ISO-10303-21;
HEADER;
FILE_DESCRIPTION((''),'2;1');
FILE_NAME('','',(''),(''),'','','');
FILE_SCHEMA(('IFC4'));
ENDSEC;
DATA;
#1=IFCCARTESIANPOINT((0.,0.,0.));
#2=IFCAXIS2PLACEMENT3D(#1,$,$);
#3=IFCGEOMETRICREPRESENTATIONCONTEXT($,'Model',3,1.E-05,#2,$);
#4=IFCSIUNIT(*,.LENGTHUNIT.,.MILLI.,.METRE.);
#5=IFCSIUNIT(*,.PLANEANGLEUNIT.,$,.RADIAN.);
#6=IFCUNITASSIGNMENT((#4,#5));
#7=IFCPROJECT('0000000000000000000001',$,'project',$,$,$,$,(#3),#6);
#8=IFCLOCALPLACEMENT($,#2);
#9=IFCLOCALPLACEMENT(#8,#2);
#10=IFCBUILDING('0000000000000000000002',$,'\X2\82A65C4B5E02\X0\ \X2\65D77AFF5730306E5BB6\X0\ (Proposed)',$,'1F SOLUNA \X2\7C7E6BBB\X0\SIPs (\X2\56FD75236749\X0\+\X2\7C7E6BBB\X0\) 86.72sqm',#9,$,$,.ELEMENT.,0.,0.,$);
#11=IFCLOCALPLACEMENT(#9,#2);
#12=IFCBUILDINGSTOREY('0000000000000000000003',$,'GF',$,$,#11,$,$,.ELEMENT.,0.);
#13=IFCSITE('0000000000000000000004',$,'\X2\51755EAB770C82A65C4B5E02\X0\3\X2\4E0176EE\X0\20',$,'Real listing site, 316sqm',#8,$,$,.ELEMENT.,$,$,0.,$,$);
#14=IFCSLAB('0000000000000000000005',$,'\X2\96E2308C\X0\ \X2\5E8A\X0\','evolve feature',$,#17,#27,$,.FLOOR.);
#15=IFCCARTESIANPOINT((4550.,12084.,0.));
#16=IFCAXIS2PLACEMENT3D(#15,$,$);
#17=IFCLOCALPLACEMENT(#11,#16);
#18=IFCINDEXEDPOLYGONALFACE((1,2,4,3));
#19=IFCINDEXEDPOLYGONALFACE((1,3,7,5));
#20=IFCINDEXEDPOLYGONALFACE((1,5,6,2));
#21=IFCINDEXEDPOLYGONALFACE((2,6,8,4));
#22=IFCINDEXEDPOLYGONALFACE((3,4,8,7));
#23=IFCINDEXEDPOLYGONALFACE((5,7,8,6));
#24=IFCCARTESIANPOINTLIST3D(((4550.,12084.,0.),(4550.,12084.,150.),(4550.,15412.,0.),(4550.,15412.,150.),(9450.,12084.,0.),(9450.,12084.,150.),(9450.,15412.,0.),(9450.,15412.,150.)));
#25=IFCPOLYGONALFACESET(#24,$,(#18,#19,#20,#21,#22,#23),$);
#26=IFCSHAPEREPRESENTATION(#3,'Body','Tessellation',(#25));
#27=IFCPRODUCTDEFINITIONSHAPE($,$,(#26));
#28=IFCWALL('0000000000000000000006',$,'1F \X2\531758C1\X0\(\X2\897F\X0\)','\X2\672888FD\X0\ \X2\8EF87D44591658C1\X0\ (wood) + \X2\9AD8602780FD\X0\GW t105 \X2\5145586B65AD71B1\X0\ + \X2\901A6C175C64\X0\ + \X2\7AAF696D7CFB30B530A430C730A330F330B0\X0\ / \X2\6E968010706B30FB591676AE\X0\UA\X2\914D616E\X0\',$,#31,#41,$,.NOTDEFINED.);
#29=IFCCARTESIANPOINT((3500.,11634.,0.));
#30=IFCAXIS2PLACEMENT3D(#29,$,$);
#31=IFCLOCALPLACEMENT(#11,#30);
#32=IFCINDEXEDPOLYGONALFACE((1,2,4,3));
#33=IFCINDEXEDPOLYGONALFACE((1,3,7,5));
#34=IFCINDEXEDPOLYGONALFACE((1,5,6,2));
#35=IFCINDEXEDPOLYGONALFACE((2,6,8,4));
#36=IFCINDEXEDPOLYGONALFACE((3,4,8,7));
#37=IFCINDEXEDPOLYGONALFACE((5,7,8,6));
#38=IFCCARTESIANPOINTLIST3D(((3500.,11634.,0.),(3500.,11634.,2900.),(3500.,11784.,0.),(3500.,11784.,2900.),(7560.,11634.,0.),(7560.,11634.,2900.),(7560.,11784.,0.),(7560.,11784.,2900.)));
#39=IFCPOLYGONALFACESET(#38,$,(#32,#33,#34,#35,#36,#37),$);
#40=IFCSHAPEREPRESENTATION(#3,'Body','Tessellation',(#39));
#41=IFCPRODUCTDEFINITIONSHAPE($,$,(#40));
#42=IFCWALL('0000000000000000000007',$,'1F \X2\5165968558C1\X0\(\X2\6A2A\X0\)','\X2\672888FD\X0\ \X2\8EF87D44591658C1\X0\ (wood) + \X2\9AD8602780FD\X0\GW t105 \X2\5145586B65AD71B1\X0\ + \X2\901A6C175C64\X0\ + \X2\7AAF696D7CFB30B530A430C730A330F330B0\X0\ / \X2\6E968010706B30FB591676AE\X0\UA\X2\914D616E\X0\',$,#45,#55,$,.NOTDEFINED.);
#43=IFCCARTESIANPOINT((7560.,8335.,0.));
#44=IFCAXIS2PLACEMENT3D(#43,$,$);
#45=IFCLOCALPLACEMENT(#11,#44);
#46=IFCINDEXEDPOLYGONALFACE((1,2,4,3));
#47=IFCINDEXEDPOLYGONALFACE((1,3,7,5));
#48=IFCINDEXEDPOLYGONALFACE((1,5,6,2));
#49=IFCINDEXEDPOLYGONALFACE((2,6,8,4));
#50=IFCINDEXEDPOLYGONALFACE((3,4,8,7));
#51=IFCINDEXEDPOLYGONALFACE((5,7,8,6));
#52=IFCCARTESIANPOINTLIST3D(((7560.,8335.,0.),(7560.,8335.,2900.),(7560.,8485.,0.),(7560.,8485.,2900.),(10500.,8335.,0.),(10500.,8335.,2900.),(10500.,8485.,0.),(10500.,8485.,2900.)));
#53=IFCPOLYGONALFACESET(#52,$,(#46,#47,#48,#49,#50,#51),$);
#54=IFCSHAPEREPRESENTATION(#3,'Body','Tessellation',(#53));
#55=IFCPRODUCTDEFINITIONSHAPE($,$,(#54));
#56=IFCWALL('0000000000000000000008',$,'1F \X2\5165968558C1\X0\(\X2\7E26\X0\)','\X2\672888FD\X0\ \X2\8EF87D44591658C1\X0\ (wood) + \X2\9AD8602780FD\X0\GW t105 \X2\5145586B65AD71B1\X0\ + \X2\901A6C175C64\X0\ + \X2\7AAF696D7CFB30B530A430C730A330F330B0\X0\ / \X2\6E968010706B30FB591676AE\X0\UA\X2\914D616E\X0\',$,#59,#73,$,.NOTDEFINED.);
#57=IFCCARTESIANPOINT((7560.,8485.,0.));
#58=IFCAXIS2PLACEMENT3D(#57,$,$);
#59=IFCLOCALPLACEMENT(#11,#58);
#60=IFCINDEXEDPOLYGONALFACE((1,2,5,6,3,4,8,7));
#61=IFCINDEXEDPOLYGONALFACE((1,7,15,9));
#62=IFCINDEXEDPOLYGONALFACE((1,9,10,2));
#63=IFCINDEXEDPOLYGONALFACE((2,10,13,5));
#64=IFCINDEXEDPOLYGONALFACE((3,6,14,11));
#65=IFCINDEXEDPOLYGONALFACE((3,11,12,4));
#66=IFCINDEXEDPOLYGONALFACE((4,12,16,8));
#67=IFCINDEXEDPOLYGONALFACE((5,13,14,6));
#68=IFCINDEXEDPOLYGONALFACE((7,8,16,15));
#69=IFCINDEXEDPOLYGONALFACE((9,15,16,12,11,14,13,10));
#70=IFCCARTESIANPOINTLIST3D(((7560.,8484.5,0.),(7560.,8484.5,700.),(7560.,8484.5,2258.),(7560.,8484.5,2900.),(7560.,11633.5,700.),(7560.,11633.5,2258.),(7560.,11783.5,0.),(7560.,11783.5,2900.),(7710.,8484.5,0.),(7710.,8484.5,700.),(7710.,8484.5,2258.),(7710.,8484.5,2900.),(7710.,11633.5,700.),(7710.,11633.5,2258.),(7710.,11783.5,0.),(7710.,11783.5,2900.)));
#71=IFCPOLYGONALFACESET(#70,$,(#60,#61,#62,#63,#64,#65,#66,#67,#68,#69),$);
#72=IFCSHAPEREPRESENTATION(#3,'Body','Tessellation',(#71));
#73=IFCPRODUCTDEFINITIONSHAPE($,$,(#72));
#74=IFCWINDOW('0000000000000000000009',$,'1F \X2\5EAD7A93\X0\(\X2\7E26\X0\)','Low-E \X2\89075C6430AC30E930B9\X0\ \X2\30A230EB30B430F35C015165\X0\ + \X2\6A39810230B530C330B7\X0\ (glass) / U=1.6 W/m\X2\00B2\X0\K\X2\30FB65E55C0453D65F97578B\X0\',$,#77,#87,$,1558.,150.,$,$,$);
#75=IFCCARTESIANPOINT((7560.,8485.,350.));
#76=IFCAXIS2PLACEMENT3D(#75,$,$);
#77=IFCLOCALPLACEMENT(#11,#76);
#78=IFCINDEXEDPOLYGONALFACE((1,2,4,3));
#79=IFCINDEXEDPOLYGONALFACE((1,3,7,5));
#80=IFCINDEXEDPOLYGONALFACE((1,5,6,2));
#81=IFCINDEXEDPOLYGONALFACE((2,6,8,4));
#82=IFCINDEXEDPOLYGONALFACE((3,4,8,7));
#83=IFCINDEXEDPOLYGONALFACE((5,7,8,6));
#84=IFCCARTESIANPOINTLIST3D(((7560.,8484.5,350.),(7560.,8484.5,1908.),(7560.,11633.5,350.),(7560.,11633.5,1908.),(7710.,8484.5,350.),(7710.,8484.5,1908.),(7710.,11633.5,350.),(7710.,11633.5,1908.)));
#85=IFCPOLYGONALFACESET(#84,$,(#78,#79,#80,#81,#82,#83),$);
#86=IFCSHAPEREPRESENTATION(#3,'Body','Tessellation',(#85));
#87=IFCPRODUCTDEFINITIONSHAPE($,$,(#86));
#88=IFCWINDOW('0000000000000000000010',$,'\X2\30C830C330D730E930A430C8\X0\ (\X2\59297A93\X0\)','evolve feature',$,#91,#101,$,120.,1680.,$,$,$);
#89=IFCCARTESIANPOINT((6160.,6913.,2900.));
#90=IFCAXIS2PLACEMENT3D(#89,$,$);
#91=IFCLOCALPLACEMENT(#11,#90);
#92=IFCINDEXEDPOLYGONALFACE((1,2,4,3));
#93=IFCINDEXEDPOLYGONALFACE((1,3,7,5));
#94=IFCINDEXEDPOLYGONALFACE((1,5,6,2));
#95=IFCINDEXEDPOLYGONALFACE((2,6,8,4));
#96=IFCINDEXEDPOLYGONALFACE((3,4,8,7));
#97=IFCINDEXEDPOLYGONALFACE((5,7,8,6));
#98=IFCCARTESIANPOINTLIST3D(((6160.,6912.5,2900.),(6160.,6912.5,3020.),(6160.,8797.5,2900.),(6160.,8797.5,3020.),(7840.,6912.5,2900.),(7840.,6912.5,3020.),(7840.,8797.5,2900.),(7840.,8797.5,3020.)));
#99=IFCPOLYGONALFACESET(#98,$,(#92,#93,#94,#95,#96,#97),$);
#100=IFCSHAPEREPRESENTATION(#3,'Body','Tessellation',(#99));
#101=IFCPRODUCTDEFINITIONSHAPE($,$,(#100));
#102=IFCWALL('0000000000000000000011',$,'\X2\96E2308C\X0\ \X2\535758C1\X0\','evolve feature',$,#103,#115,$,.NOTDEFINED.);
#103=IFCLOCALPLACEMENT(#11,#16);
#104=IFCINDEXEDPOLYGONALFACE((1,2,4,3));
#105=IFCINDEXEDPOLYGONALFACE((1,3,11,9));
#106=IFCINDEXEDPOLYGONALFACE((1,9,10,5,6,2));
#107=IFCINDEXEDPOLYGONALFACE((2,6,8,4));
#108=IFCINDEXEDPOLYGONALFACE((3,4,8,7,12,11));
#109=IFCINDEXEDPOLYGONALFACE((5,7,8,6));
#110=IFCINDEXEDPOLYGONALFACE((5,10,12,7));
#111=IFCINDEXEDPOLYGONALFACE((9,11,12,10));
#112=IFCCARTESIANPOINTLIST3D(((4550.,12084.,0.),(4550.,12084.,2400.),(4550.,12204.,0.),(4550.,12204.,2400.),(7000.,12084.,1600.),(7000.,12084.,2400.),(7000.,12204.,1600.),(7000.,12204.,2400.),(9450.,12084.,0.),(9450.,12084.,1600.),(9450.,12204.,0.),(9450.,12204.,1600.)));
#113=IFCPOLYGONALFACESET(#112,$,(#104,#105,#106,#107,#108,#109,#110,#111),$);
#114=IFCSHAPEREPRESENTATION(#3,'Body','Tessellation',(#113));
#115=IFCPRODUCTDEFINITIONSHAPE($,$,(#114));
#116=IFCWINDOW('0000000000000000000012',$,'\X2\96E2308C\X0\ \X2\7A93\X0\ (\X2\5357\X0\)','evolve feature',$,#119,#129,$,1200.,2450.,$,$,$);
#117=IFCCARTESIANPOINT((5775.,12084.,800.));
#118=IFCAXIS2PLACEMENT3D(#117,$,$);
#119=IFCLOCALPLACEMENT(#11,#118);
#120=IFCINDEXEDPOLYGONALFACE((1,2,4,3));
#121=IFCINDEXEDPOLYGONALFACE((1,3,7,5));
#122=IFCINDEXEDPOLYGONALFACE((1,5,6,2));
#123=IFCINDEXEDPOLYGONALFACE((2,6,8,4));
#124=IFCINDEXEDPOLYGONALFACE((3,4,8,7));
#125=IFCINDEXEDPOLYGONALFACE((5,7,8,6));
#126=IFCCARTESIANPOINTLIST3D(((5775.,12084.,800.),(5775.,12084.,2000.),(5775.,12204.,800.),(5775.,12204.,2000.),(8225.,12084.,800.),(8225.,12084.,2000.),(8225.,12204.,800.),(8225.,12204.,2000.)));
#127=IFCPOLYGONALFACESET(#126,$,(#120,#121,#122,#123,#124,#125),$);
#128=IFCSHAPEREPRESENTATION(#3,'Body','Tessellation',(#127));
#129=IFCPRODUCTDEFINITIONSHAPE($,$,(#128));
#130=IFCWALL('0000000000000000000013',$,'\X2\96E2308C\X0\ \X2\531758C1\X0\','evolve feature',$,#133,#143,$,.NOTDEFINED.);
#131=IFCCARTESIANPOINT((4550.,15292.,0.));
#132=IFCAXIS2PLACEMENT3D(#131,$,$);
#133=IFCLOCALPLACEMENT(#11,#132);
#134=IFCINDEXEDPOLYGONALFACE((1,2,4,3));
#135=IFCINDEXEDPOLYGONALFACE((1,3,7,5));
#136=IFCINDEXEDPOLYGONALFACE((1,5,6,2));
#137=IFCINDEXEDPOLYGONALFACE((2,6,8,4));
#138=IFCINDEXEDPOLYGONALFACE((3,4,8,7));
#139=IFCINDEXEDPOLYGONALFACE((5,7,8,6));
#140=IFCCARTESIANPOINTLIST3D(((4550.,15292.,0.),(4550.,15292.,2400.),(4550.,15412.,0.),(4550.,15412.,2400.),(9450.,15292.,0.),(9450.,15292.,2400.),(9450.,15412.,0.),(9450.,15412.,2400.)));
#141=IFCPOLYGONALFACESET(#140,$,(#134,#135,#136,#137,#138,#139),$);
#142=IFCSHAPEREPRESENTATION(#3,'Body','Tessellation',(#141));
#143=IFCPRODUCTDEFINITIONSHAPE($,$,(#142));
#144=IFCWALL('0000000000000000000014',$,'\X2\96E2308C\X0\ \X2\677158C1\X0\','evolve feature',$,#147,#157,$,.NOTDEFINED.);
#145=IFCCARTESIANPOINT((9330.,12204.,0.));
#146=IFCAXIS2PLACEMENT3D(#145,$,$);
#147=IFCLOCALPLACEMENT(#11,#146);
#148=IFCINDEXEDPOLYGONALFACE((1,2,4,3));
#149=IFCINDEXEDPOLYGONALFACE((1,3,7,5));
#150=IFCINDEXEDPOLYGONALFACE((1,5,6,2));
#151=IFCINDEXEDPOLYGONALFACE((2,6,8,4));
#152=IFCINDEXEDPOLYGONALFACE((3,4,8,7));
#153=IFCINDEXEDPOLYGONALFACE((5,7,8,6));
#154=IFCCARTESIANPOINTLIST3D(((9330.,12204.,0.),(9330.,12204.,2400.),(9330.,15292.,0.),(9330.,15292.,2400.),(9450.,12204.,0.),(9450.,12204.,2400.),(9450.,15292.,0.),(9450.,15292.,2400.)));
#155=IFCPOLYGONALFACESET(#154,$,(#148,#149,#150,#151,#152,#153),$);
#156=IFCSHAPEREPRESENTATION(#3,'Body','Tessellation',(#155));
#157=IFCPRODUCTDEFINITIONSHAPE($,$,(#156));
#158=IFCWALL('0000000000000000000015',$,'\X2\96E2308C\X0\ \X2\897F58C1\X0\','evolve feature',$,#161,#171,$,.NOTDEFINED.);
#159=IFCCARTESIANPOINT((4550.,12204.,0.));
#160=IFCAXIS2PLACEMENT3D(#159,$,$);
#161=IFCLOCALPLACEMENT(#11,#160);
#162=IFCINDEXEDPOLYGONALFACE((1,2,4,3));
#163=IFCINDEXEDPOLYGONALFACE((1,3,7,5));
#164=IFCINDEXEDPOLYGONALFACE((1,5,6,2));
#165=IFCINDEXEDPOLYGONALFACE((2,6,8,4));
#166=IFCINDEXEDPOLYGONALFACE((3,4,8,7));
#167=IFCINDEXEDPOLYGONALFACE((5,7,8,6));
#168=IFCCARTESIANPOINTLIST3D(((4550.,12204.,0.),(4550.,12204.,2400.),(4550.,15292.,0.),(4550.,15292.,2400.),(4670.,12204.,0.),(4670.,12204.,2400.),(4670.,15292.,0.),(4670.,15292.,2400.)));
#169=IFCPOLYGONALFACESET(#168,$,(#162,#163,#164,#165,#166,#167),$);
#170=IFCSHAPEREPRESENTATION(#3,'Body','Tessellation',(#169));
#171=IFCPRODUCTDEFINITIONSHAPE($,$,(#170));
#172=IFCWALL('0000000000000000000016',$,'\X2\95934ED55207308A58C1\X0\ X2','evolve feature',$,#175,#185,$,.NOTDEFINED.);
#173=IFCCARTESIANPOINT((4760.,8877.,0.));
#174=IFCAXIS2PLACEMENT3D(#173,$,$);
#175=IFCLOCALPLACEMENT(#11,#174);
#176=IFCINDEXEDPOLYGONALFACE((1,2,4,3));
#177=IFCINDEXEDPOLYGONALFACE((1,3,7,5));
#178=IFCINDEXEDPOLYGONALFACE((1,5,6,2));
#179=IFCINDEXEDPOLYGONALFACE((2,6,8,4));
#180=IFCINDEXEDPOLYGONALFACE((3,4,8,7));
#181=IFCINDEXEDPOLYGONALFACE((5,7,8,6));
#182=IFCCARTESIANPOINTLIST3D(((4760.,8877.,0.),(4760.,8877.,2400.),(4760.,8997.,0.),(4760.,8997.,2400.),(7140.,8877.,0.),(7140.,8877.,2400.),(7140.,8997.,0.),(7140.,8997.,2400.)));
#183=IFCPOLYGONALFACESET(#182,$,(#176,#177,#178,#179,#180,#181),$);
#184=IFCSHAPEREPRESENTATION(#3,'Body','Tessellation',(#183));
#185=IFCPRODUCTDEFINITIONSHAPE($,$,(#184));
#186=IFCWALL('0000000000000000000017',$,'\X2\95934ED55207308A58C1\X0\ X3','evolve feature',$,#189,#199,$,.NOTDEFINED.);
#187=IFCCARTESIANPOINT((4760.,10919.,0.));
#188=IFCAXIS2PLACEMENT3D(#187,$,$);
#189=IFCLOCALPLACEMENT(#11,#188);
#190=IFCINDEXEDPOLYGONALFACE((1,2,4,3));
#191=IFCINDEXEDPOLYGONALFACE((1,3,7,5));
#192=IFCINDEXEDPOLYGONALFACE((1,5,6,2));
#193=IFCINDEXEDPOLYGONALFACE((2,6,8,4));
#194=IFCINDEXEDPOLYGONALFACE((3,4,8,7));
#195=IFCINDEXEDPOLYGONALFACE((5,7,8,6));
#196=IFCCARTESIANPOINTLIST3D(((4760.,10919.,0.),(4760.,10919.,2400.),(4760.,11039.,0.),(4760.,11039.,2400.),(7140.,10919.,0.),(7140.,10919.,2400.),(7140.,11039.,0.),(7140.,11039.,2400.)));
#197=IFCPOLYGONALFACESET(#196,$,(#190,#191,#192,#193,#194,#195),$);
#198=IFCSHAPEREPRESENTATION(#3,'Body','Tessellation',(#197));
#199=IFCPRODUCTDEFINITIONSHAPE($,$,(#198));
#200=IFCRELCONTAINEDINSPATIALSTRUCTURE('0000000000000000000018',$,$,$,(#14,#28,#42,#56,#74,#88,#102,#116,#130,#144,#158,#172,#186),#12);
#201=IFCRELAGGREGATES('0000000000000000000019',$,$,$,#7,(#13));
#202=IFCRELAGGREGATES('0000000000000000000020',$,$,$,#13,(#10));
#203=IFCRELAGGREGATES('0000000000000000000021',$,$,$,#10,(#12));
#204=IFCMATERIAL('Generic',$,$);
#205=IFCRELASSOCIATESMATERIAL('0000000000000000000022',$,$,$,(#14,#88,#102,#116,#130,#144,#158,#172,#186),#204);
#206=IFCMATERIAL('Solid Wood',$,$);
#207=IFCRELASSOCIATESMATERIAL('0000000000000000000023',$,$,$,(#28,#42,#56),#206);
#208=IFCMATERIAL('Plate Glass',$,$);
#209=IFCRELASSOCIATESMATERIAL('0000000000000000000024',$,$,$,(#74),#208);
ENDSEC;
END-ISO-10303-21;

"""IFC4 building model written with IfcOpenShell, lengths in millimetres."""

from ifc_helpers import new_model, si_unit, frame, frame_2d, origin, place, context, project, spatial, rectangle, extrude, material, element, fill, save


model = new_model("IFC4")

# Units and contexts
model_context = context("Model", 3, precision=1e-05, world=origin())
ifc_project = project(units=[si_unit("LENGTHUNIT", "METRE", prefix="MILLI"), si_unit("PLANEANGLEUNIT", "RADIAN")], contexts=[model_context])

# Site, building, storey
site_placement = place(None, origin())
site = spatial("IfcSite", under=ifc_project, at=site_placement, Name="兵庫県芦屋市3丁目20", ObjectType="Real listing site, 316sqm", CompositionType="ELEMENT", RefElevation=0.0)
building_placement = place(site_placement, origin())
building = spatial("IfcBuilding", under=site, at=building_placement, Name="芦屋市 旗竿地の家 (Proposed)", ObjectType="1F SOLUNA 籾殻SIPs (国産杉+籾殻) 86.72sqm", CompositionType="ELEMENT", ElevationOfRefHeight=0.0, ElevationOfTerrain=0.0)
storey_placement = place(building_placement, origin())
storey = spatial("IfcBuildingStorey", under=building, at=storey_placement, Name="GF", CompositionType="ELEMENT", Elevation=0.0)

# Slab
ifc_material_1 = material(Name="Solid Wood")
ifc_material_2 = material(Name="Generic")
slab_1_placement = place(storey_placement, frame((4550.0, 12084.0, 0.0)))
element("IfcSlab", 1, at=slab_1_placement, inside=storey, material=ifc_material_2, Name="離れ 床", Description="evolve feature", PredefinedType="FLOOR", context=model_context, shape_type="SweptSolid", body=[
    extrude(rectangle(XDim=4900.0, YDim=3328.0, at=frame_2d((2450.0, 1664.0))), frame((4550.0, 12084.0, 0.0)), (0.0, 0.0, 1.0), 150.0),
])

# Walls
wall_1_placement = place(storey_placement, frame((3500.0, 11634.0, 0.0)))
element("IfcWall", 2, at=wall_1_placement, inside=storey, material=ifc_material_1, Name="1F 北壁(西)", Description="木製 軸組外壁 (wood) + 高性能GW t105 充填断熱 + 通気層 + 窯業系サイディング / 準耐火・外皮UA配慮", PredefinedType="NOTDEFINED", context=model_context, shape_type="SweptSolid", body=[
    extrude(rectangle(XDim=4060.0, YDim=150.0, at=frame_2d((2030.0, 75.0))), frame((3500.0, 11634.0, 0.0)), (0.0, 0.0, 1.0), 2900.0),
])
wall_2_placement = place(storey_placement, frame((7560.0, 8335.0, 0.0)))
element("IfcWall", 3, at=wall_2_placement, inside=storey, material=ifc_material_1, Name="1F 入隅壁(横)", Description="木製 軸組外壁 (wood) + 高性能GW t105 充填断熱 + 通気層 + 窯業系サイディング / 準耐火・外皮UA配慮", PredefinedType="NOTDEFINED", context=model_context, shape_type="SweptSolid", body=[
    extrude(rectangle(XDim=2940.0, YDim=150.0, at=frame_2d((1470.0, 75.0))), frame((7560.0, 8335.0, 0.0)), (0.0, 0.0, 1.0), 2900.0),
])

# Wall, opening, window
wall_3_placement = place(storey_placement, frame((7560.0, 8485.0, 0.0)))
wall_3 = element("IfcWall", 4, at=wall_3_placement, inside=storey, material=ifc_material_1, Name="1F 入隅壁(縦)", Description="木製 軸組外壁 (wood) + 高性能GW t105 充填断熱 + 通気層 + 窯業系サイディング / 準耐火・外皮UA配慮", PredefinedType="NOTDEFINED", context=model_context, shape_type="SweptSolid", body=[
    extrude(rectangle(XDim=150.0, YDim=3299.0, at=frame_2d((75.0, 1649.0))), frame((7560.0, 8485.0, 0.0)), (0.0, 0.0, 1.0), 2900.0),
])
opening_1_placement = place(storey_placement, frame((7560.0, 8485.0, 350.0)))
opening_1 = element("IfcOpeningElement", 5, at=opening_1_placement, cuts=wall_3, PredefinedType="NOTDEFINED", context=model_context, shape_type="SweptSolid", body=[
    extrude(rectangle(XDim=150.0, YDim=3149.0, at=frame_2d((75.0, 1574.0))), frame((7560.0, 8485.0, 350.0)), (0.0, 0.0, 1.0), 1558.0),
])
ifc_material_3 = material(Name="Plate Glass")
window_1_placement = place(storey_placement, frame((7560.0, 8485.0, 350.0)))
window_1 = element("IfcWindow", 6, at=window_1_placement, inside=storey, material=ifc_material_3, Name="1F 庭窓(縦)", Description="Low-E 複層ガラス アルゴン封入 + 樹脂サッシ (glass) / U=1.6 W/m²K・日射取得型", OverallHeight=1558.0, OverallWidth=150.0, context=model_context, shape_type="SweptSolid", body=[
    extrude(rectangle(XDim=150.0, YDim=3149.0, at=frame_2d((75.0, 1574.0))), frame((7560.0, 8485.0, 350.0)), (0.0, 0.0, 1.0), 1558.0),
])
fill(opening_1, window_1)

# Window
window_2_placement = place(storey_placement, frame((6160.0, 6913.0, 2900.0)))
element("IfcWindow", 7, at=window_2_placement, inside=storey, material=ifc_material_2, Name="トップライト (天窓)", Description="evolve feature", OverallHeight=120.0, OverallWidth=1680.0, context=model_context, shape_type="SweptSolid", body=[
    extrude(rectangle(XDim=1680.0, YDim=1885.0, at=frame_2d((840.0, 942.0))), frame((6160.0, 6913.0, 2900.0)), (0.0, 0.0, 1.0), 120.0),
])

# Wall, opening, window
wall_4_placement = place(storey_placement, frame((4550.0, 12084.0, 0.0)))
wall_4 = element("IfcWall", 8, at=wall_4_placement, inside=storey, material=ifc_material_2, Name="離れ 南壁", Description="evolve feature", PredefinedType="NOTDEFINED", context=model_context, shape_type="SweptSolid", body=[
    extrude(rectangle(XDim=4900.0, YDim=120.0, at=frame_2d((2450.0, 60.0))), frame((4550.0, 12084.0, 0.0)), (0.0, 0.0, 1.0), 2400.0),
])
opening_2_placement = place(storey_placement, frame((5775.0, 12084.0, 800.0)))
opening_2 = element("IfcOpeningElement", 9, at=opening_2_placement, cuts=wall_4, PredefinedType="NOTDEFINED", context=model_context, shape_type="SweptSolid", body=[
    extrude(rectangle(XDim=2450.0, YDim=120.0, at=frame_2d((1225.0, 60.0))), frame((5775.0, 12084.0, 800.0)), (0.0, 0.0, 1.0), 1200.0),
])
window_3_placement = place(storey_placement, frame((5775.0, 12084.0, 800.0)))
window_3 = element("IfcWindow", 10, at=window_3_placement, inside=storey, material=ifc_material_2, Name="離れ 窓 (南)", Description="evolve feature", OverallHeight=1200.0, OverallWidth=2450.0, context=model_context, shape_type="SweptSolid", body=[
    extrude(rectangle(XDim=2450.0, YDim=120.0, at=frame_2d((1225.0, 60.0))), frame((5775.0, 12084.0, 800.0)), (0.0, 0.0, 1.0), 1200.0),
])
fill(opening_2, window_3)

# Walls
wall_5_placement = place(storey_placement, frame((4550.0, 15292.0, 0.0)))
element("IfcWall", 11, at=wall_5_placement, inside=storey, material=ifc_material_2, Name="離れ 北壁", Description="evolve feature", PredefinedType="NOTDEFINED", context=model_context, shape_type="SweptSolid", body=[
    extrude(rectangle(XDim=4900.0, YDim=120.0, at=frame_2d((2450.0, 60.0))), frame((4550.0, 15292.0, 0.0)), (0.0, 0.0, 1.0), 2400.0),
])
wall_6_placement = place(storey_placement, frame((9330.0, 12204.0, 0.0)))
element("IfcWall", 12, at=wall_6_placement, inside=storey, material=ifc_material_2, Name="離れ 東壁", Description="evolve feature", PredefinedType="NOTDEFINED", context=model_context, shape_type="SweptSolid", body=[
    extrude(rectangle(XDim=120.0, YDim=3088.0, at=frame_2d((60.0, 1544.0))), frame((9330.0, 12204.0, 0.0)), (0.0, 0.0, 1.0), 2400.0),
])
wall_7_placement = place(storey_placement, frame((4550.0, 12204.0, 0.0)))
element("IfcWall", 13, at=wall_7_placement, inside=storey, material=ifc_material_2, Name="離れ 西壁", Description="evolve feature", PredefinedType="NOTDEFINED", context=model_context, shape_type="SweptSolid", body=[
    extrude(rectangle(XDim=120.0, YDim=3088.0, at=frame_2d((60.0, 1544.0))), frame((4550.0, 12204.0, 0.0)), (0.0, 0.0, 1.0), 2400.0),
])
wall_8_placement = place(storey_placement, frame((4760.0, 8877.0, 0.0)))
element("IfcWall", 14, at=wall_8_placement, inside=storey, material=ifc_material_2, Name="間仕切り壁 X2", Description="evolve feature", PredefinedType="NOTDEFINED", context=model_context, shape_type="SweptSolid", body=[
    extrude(rectangle(XDim=2380.0, YDim=120.0, at=frame_2d((1190.0, 60.0))), frame((4760.0, 8877.0, 0.0)), (0.0, 0.0, 1.0), 2400.0),
])
wall_9_placement = place(storey_placement, frame((4760.0, 10919.0, 0.0)))
element("IfcWall", 15, at=wall_9_placement, inside=storey, material=ifc_material_2, Name="間仕切り壁 X3", Description="evolve feature", PredefinedType="NOTDEFINED", context=model_context, shape_type="SweptSolid", body=[
    extrude(rectangle(XDim=2380.0, YDim=120.0, at=frame_2d((1190.0, 60.0))), frame((4760.0, 10919.0, 0.0)), (0.0, 0.0, 1.0), 2400.0),
])

save(model, "model.ifc")
